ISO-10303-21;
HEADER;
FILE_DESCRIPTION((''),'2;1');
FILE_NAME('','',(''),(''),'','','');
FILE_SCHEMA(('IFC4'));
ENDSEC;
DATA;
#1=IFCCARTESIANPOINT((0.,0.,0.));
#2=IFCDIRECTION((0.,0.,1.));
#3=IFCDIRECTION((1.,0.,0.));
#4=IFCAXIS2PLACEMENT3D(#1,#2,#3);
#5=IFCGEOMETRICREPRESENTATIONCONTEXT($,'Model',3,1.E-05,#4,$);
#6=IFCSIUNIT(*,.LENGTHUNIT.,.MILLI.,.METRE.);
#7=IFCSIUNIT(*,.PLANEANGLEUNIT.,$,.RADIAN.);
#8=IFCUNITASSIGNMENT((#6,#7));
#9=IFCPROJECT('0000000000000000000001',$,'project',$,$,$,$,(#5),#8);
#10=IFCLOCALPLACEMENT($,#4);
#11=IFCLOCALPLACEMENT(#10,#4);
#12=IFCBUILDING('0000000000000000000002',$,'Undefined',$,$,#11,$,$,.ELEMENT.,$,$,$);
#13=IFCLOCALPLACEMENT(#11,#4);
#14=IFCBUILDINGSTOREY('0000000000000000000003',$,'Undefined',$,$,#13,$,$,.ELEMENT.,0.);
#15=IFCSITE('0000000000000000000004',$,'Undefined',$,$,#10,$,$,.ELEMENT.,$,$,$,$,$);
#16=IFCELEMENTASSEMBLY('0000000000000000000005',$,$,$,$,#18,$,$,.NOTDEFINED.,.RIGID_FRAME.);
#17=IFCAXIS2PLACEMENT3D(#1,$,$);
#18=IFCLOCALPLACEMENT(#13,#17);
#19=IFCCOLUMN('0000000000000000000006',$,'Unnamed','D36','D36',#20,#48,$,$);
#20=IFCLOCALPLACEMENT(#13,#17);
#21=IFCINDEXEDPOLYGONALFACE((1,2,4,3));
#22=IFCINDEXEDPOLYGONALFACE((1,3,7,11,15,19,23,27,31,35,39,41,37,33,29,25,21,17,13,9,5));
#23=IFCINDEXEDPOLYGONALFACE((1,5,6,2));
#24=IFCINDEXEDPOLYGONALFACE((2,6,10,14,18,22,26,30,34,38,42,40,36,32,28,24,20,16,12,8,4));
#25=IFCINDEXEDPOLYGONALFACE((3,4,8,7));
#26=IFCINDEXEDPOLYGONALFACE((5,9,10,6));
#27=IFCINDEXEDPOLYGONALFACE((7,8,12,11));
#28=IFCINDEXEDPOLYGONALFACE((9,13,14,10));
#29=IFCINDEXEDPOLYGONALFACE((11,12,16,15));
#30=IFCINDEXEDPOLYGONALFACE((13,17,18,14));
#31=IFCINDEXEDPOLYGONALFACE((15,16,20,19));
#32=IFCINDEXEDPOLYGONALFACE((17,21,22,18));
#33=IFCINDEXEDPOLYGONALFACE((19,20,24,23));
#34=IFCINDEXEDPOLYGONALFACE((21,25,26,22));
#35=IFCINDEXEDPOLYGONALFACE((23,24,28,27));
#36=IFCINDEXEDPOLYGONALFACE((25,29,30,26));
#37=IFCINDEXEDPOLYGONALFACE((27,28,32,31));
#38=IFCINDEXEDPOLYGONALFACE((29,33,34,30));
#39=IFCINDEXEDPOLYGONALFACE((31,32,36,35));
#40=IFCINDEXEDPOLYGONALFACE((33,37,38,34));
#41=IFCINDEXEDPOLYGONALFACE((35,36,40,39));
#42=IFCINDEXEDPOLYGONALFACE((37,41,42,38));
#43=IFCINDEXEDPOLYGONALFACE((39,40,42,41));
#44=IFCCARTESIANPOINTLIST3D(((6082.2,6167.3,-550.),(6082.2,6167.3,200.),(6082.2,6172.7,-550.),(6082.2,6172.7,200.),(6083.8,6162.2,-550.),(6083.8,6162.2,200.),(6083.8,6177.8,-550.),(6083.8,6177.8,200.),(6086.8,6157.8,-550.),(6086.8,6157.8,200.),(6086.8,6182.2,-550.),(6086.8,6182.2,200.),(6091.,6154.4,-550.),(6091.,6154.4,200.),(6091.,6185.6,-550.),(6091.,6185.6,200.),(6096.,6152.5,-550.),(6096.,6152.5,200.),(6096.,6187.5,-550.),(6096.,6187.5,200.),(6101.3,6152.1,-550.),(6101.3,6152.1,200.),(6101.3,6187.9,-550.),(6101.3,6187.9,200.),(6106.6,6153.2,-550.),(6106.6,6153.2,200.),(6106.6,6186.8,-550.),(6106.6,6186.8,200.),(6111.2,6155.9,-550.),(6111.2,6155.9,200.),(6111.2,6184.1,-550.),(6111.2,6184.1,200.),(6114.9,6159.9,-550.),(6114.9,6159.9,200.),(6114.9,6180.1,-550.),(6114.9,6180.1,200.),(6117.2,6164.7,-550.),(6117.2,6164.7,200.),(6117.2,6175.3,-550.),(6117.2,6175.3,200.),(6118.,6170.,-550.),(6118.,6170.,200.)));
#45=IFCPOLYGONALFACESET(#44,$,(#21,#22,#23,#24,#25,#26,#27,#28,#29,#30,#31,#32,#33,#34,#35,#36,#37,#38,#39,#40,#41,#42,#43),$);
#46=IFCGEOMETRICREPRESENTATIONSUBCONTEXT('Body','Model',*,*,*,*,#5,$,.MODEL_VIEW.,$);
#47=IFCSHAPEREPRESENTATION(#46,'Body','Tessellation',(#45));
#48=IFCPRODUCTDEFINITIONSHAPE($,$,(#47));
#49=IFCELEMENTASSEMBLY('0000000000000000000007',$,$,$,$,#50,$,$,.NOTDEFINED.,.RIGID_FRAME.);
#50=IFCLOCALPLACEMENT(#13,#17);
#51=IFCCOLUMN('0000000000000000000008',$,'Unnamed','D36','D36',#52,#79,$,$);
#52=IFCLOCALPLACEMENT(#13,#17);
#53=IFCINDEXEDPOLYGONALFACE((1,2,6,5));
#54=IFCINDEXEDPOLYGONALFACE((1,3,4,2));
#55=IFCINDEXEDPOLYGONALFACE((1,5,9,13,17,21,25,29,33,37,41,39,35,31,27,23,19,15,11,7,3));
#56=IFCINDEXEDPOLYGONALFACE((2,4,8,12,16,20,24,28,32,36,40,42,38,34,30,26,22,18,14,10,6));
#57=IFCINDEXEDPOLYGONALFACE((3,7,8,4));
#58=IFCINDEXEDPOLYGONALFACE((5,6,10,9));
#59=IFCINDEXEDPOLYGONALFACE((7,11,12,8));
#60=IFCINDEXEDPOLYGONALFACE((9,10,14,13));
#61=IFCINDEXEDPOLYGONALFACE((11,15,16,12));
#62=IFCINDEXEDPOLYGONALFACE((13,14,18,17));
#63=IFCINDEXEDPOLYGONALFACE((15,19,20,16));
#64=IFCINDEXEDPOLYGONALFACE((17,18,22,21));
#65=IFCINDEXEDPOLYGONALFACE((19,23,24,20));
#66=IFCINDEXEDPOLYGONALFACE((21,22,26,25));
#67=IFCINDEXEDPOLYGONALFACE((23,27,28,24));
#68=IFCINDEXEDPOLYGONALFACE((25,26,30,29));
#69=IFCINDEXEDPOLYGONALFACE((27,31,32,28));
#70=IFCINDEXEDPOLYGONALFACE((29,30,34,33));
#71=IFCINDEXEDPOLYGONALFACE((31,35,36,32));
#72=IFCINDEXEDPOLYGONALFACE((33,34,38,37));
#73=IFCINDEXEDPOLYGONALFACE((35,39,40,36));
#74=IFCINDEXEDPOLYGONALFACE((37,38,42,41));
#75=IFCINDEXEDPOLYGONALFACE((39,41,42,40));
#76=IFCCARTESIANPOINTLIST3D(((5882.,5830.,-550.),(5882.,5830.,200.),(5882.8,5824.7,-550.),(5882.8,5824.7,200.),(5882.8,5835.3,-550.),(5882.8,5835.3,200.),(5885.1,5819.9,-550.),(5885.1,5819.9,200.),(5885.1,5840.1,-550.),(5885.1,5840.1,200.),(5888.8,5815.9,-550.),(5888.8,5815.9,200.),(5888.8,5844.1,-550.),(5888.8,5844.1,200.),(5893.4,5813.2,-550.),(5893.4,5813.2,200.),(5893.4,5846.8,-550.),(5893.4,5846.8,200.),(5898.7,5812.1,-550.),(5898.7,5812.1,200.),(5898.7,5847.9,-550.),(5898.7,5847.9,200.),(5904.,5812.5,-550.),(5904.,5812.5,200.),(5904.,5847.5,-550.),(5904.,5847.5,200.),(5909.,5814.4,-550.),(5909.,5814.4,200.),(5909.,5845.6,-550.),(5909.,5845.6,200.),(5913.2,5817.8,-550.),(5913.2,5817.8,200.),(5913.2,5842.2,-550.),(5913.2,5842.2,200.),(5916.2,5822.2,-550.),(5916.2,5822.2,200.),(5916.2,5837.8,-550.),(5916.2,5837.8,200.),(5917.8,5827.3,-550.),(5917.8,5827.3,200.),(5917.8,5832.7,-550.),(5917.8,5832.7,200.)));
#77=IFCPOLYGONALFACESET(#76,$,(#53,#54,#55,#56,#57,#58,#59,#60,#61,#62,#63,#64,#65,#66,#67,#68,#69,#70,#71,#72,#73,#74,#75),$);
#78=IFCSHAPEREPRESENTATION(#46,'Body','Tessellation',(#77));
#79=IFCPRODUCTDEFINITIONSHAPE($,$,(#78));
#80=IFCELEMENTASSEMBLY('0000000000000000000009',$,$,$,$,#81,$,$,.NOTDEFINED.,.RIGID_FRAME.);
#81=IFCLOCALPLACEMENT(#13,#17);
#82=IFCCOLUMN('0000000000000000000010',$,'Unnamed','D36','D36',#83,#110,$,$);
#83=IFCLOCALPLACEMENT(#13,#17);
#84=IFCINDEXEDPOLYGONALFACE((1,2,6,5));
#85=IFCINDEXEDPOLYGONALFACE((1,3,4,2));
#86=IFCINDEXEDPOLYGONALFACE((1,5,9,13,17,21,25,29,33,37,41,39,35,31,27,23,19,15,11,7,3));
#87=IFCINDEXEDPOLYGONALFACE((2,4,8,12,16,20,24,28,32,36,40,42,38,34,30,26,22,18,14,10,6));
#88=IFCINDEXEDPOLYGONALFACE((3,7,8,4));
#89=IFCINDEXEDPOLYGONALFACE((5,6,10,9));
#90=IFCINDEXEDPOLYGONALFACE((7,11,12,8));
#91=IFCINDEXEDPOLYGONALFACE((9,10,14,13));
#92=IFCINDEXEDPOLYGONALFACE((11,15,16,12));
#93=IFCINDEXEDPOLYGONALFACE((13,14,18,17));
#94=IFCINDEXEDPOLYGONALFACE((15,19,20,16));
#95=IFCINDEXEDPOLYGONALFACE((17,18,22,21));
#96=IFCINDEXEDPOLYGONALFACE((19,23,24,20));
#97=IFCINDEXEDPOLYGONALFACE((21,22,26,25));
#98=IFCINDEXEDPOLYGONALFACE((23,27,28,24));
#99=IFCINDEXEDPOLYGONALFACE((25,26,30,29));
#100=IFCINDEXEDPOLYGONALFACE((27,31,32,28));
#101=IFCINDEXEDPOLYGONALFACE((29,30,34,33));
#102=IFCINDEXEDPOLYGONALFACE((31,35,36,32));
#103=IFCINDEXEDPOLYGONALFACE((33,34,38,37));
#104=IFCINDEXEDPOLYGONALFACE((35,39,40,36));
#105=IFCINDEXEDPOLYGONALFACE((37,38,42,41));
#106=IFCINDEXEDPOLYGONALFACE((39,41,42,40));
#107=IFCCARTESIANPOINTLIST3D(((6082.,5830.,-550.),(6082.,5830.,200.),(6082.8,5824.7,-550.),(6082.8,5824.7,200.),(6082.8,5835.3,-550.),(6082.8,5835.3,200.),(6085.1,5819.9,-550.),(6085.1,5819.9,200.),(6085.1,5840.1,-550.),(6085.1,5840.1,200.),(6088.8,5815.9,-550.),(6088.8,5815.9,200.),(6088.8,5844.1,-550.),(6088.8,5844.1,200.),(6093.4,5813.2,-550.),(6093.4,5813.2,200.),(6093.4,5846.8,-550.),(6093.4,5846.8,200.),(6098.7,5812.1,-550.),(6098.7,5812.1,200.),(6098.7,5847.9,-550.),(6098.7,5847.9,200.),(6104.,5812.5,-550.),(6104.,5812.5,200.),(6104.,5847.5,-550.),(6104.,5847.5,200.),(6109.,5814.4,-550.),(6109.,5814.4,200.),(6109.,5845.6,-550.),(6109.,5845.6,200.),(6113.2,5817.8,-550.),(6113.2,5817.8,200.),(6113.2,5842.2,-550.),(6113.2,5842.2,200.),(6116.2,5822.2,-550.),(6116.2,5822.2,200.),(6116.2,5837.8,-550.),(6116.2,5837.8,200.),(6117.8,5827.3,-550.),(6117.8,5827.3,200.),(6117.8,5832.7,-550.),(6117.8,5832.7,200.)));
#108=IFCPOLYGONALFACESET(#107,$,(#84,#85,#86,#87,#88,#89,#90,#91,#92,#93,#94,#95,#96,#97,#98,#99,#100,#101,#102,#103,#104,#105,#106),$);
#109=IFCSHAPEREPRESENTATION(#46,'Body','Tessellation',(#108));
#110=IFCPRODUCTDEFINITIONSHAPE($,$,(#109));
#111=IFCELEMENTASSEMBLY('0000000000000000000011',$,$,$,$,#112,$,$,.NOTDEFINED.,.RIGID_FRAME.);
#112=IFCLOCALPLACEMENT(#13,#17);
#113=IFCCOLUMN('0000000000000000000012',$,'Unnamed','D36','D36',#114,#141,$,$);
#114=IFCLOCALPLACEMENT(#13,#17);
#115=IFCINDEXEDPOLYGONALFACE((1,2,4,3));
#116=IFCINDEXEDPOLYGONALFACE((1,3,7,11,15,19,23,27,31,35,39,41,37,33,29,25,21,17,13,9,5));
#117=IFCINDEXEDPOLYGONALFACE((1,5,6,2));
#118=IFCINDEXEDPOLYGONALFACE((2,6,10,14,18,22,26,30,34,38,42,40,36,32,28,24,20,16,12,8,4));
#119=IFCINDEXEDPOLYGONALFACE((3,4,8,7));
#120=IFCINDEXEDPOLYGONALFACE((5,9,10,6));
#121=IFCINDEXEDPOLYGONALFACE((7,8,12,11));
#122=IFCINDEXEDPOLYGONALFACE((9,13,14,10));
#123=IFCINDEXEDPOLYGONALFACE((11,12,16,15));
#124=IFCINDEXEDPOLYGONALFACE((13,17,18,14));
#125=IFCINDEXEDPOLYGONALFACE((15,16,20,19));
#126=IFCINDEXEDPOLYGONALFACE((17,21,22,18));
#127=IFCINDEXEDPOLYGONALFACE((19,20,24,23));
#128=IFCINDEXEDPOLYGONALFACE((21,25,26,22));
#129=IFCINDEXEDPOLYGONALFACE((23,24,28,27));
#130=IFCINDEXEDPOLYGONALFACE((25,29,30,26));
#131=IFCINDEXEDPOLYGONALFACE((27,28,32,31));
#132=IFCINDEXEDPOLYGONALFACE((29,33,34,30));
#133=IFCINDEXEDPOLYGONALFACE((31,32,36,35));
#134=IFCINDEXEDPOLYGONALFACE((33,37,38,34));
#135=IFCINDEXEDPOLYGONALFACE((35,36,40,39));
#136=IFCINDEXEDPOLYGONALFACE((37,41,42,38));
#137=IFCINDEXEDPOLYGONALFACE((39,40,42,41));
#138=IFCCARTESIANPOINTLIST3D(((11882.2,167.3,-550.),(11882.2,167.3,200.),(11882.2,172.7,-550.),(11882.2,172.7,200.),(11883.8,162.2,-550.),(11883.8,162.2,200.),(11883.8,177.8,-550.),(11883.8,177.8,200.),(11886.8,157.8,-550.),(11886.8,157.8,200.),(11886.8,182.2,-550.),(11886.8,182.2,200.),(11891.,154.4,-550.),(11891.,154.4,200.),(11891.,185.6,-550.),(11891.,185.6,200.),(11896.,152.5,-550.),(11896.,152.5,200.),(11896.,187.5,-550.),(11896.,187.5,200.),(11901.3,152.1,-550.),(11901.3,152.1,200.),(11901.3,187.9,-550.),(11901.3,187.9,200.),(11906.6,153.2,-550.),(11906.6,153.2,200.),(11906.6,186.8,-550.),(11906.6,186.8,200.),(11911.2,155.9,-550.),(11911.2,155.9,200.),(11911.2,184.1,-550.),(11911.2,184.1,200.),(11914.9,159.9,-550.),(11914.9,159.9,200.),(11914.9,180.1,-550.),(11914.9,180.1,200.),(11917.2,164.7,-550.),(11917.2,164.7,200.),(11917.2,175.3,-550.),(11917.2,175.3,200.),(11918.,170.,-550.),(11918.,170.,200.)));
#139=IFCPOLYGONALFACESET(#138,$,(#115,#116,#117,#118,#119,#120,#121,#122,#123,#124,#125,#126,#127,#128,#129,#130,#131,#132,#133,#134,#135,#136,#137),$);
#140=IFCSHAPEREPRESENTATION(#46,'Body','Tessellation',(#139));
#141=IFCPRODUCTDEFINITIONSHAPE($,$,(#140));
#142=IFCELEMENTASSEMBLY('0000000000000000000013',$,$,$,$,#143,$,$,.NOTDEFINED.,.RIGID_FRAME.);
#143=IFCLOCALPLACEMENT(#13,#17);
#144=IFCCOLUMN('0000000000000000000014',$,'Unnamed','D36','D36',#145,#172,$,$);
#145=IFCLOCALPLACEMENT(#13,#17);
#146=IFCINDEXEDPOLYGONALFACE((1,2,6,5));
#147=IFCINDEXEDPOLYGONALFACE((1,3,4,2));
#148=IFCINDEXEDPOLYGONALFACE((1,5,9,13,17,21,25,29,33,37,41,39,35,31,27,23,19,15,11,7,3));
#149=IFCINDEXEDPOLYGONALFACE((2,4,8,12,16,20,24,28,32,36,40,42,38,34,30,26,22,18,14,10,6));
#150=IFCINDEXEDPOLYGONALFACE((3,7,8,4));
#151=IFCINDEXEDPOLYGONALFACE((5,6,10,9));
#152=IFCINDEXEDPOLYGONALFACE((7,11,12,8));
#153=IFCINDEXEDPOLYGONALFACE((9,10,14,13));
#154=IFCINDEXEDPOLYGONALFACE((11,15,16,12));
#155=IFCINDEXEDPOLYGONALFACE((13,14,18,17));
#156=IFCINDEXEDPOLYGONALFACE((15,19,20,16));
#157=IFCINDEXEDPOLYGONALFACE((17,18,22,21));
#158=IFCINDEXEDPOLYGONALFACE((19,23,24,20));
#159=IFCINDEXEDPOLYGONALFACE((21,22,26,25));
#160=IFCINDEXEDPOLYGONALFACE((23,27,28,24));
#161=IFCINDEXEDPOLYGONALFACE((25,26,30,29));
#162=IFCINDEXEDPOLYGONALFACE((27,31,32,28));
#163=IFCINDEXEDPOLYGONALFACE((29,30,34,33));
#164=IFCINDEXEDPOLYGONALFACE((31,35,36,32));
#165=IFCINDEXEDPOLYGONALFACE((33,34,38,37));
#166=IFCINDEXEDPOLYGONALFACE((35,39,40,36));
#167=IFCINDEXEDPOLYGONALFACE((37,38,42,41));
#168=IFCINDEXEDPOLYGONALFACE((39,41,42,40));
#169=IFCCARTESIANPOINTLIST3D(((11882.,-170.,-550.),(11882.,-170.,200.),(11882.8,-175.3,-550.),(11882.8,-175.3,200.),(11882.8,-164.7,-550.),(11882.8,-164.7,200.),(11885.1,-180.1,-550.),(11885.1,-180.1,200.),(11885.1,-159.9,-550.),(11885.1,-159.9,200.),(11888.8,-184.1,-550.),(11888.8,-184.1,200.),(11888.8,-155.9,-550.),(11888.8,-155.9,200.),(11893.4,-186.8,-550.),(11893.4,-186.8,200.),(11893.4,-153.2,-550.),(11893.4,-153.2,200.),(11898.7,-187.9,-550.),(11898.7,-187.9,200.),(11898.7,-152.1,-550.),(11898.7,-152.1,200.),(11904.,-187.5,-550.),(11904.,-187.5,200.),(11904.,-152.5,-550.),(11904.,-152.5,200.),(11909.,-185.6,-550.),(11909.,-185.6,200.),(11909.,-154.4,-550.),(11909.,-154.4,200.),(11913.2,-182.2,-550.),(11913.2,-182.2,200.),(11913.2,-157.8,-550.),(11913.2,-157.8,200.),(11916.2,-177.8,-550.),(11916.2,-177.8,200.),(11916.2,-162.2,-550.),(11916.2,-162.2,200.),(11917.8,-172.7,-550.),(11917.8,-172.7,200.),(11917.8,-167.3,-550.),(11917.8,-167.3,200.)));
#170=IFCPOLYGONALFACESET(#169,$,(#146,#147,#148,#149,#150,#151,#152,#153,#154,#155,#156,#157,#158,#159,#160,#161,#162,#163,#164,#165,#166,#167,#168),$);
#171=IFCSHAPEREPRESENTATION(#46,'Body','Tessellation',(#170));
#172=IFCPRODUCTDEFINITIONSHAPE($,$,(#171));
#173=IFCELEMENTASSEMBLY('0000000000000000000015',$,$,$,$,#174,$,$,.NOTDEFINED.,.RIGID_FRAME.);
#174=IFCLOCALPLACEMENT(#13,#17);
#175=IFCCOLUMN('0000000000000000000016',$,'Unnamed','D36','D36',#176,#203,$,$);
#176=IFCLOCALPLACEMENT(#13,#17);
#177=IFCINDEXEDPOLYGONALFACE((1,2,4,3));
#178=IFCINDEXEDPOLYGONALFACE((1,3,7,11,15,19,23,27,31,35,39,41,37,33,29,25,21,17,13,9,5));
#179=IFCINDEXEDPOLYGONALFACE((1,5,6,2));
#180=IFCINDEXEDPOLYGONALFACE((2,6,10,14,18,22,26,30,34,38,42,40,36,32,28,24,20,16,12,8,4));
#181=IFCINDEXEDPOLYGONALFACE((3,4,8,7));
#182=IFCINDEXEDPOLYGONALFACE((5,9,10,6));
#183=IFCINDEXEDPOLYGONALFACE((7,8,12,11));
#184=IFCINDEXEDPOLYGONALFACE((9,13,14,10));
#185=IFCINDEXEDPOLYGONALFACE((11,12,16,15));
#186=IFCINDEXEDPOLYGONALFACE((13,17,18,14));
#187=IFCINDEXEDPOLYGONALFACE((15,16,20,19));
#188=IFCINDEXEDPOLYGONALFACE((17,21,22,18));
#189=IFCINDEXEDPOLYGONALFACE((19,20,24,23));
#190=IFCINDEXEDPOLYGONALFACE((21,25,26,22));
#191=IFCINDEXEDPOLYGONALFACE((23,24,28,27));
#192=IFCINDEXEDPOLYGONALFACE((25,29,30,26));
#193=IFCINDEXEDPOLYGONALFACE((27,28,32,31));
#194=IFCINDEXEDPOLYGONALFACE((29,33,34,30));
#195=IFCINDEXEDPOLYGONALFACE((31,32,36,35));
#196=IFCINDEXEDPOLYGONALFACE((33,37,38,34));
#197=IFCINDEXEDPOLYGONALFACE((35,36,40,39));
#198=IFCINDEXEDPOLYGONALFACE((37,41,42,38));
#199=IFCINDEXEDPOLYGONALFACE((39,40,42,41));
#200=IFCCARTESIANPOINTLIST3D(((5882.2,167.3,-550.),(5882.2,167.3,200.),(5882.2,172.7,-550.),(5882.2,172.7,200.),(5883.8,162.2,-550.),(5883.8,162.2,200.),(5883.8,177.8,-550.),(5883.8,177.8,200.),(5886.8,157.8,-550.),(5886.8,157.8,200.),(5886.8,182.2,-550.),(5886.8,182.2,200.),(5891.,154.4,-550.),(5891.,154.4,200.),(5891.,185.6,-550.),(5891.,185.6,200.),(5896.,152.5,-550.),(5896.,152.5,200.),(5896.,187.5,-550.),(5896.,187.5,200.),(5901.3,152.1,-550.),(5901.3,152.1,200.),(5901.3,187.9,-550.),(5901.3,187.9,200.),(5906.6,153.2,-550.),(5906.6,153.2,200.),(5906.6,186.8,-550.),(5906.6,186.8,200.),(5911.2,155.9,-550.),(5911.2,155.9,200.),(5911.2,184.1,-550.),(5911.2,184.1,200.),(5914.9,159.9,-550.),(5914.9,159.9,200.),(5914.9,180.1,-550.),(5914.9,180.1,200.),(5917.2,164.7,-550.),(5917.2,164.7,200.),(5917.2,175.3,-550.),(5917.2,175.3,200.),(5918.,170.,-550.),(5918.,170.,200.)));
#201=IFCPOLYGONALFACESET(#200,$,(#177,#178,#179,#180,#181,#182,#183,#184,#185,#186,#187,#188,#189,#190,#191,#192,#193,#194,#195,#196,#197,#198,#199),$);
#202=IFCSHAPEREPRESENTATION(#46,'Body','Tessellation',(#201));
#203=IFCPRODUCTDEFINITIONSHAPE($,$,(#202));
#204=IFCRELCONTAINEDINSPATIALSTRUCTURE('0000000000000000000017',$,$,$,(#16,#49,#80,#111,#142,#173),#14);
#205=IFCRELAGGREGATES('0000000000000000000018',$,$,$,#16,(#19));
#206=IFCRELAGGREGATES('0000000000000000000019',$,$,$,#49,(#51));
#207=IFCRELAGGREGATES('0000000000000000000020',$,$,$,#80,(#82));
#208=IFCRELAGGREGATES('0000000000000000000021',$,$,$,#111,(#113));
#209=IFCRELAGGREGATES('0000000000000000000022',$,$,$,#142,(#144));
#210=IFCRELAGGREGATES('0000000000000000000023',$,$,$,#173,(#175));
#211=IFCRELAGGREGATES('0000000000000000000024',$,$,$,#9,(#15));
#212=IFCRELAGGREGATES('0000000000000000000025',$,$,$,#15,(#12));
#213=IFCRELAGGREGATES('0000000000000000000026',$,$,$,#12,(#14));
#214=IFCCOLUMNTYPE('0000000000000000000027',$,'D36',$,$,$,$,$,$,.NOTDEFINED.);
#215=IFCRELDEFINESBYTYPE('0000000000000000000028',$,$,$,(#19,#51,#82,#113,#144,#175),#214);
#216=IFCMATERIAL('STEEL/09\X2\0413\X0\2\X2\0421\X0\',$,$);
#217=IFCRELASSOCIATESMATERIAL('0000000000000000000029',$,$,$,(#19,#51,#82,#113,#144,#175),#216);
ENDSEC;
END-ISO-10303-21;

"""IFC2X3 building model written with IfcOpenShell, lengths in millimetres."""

from ifc_helpers import new_model, si_unit, frame, origin_with_axes, origin_2d_with_axis, place, context, subcontext, project, spatial, circle, extrude, material, type_object, element, aggregate, save


model = new_model("IFC2X3")

# Units and contexts
model_context = context("Model", 3, precision=1e-05, world=origin_with_axes())
body_context = subcontext(model_context, "Body", "Model", "MODEL_VIEW")
ifc_project = project(units=[si_unit("LENGTHUNIT", "METRE", prefix="MILLI"), si_unit("PLANEANGLEUNIT", "RADIAN")], contexts=[model_context])

# Site, building, storey
site_placement = place(None, origin_with_axes())
site = spatial("IfcSite", under=ifc_project, at=site_placement, Name="Undefined", CompositionType="ELEMENT")
building_placement = place(site_placement, origin_with_axes())
building = spatial("IfcBuilding", under=site, at=building_placement, Name="Undefined", CompositionType="ELEMENT")
storey_placement = place(building_placement, origin_with_axes())
storey = spatial("IfcBuildingStorey", under=building, at=storey_placement, Name="Undefined", CompositionType="ELEMENT", Elevation=0.0)

# Element assemblies, columns
ifc_material_1 = material(Name="STEEL/09Г2С")
column_type_1 = type_object("IfcColumnType", Name="D36", PredefinedType="NOTDEFINED")
assembly_1_placement = place(storey_placement, origin_with_axes())
assembly_1 = element("IfcElementAssembly", 1, at=assembly_1_placement, inside=storey, AssemblyPlace="NOTDEFINED", PredefinedType="RIGID_FRAME")
column_1_placement = place(assembly_1_placement, frame((6100.0, 6170.0, -550.0), z_axis=(0.0, 0.0, 1.0), x_axis=(0.0, -1.0, 0.0)))
column_1 = element("IfcColumn", 2, at=column_1_placement, type_object=column_type_1, material=ifc_material_1, Name="Unnamed", Description="D36", ObjectType="D36", context=body_context, shape_type="SweptSolid", body=[
    extrude(circle(Radius=18.0, at=origin_2d_with_axis()), frame((0.0, 0.0, 750.0), z_axis=(0.0, 0.0, -1.0), x_axis=(0.0, 1.0, 0.0)), (0.0, 0.0, 1.0), 750.0),
])
aggregate(assembly_1, [column_1])
assembly_2_placement = place(storey_placement, origin_with_axes())
assembly_2 = element("IfcElementAssembly", 3, at=assembly_2_placement, inside=storey, AssemblyPlace="NOTDEFINED", PredefinedType="RIGID_FRAME")
column_2_placement = place(assembly_2_placement, frame((5900.0, 5830.0, -550.0), z_axis=(0.0, 0.0, 1.0), x_axis=(0.0, 1.0, 0.0)))
column_2 = element("IfcColumn", 4, at=column_2_placement, type_object=column_type_1, material=ifc_material_1, Name="Unnamed", Description="D36", ObjectType="D36", context=body_context, shape_type="SweptSolid", body=[
    extrude(circle(Radius=18.0, at=origin_2d_with_axis()), frame((0.0, 0.0, 750.0), z_axis=(0.0, 0.0, -1.0), x_axis=(0.0, 1.0, 0.0)), (0.0, 0.0, 1.0), 750.0),
])
aggregate(assembly_2, [column_2])
assembly_3_placement = place(storey_placement, origin_with_axes())
assembly_3 = element("IfcElementAssembly", 5, at=assembly_3_placement, inside=storey, AssemblyPlace="NOTDEFINED", PredefinedType="RIGID_FRAME")
column_3_placement = place(assembly_3_placement, frame((6100.0, 5830.0, -550.0), z_axis=(0.0, 0.0, 1.0), x_axis=(0.0, 1.0, 0.0)))
column_3 = element("IfcColumn", 6, at=column_3_placement, type_object=column_type_1, material=ifc_material_1, Name="Unnamed", Description="D36", ObjectType="D36", context=body_context, shape_type="SweptSolid", body=[
    extrude(circle(Radius=18.0, at=origin_2d_with_axis()), frame((0.0, 0.0, 750.0), z_axis=(0.0, 0.0, -1.0), x_axis=(0.0, 1.0, 0.0)), (0.0, 0.0, 1.0), 750.0),
])
aggregate(assembly_3, [column_3])
assembly_4_placement = place(storey_placement, origin_with_axes())
assembly_4 = element("IfcElementAssembly", 7, at=assembly_4_placement, inside=storey, AssemblyPlace="NOTDEFINED", PredefinedType="RIGID_FRAME")
column_4_placement = place(assembly_4_placement, frame((11900.0, 170.0, -550.0), z_axis=(0.0, 0.0, 1.0), x_axis=(0.0, -1.0, 0.0)))
column_4 = element("IfcColumn", 8, at=column_4_placement, type_object=column_type_1, material=ifc_material_1, Name="Unnamed", Description="D36", ObjectType="D36", context=body_context, shape_type="SweptSolid", body=[
    extrude(circle(Radius=18.0, at=origin_2d_with_axis()), frame((0.0, 0.0, 750.0), z_axis=(0.0, 0.0, -1.0), x_axis=(0.0, 1.0, 0.0)), (0.0, 0.0, 1.0), 750.0),
])
aggregate(assembly_4, [column_4])
assembly_5_placement = place(storey_placement, origin_with_axes())
assembly_5 = element("IfcElementAssembly", 9, at=assembly_5_placement, inside=storey, AssemblyPlace="NOTDEFINED", PredefinedType="RIGID_FRAME")
column_5_placement = place(assembly_5_placement, frame((11900.0, -170.0, -550.0), z_axis=(0.0, 0.0, 1.0), x_axis=(0.0, 1.0, 0.0)))
column_5 = element("IfcColumn", 10, at=column_5_placement, type_object=column_type_1, material=ifc_material_1, Name="Unnamed", Description="D36", ObjectType="D36", context=body_context, shape_type="SweptSolid", body=[
    extrude(circle(Radius=18.0, at=origin_2d_with_axis()), frame((0.0, 0.0, 750.0), z_axis=(0.0, 0.0, -1.0), x_axis=(0.0, 1.0, 0.0)), (0.0, 0.0, 1.0), 750.0),
])
aggregate(assembly_5, [column_5])
assembly_6_placement = place(storey_placement, origin_with_axes())
assembly_6 = element("IfcElementAssembly", 11, at=assembly_6_placement, inside=storey, AssemblyPlace="NOTDEFINED", PredefinedType="RIGID_FRAME")
column_6_placement = place(assembly_6_placement, frame((5900.0, 170.0, -550.0), z_axis=(0.0, 0.0, 1.0), x_axis=(0.0, -1.0, 0.0)))
column_6 = element("IfcColumn", 12, at=column_6_placement, type_object=column_type_1, material=ifc_material_1, Name="Unnamed", Description="D36", ObjectType="D36", context=body_context, shape_type="SweptSolid", body=[
    extrude(circle(Radius=18.0, at=origin_2d_with_axis()), frame((0.0, 0.0, 750.0), z_axis=(0.0, 0.0, -1.0), x_axis=(0.0, 1.0, 0.0)), (0.0, 0.0, 1.0), 750.0),
])
aggregate(assembly_6, [column_6])

save(model, "model.ifc")
